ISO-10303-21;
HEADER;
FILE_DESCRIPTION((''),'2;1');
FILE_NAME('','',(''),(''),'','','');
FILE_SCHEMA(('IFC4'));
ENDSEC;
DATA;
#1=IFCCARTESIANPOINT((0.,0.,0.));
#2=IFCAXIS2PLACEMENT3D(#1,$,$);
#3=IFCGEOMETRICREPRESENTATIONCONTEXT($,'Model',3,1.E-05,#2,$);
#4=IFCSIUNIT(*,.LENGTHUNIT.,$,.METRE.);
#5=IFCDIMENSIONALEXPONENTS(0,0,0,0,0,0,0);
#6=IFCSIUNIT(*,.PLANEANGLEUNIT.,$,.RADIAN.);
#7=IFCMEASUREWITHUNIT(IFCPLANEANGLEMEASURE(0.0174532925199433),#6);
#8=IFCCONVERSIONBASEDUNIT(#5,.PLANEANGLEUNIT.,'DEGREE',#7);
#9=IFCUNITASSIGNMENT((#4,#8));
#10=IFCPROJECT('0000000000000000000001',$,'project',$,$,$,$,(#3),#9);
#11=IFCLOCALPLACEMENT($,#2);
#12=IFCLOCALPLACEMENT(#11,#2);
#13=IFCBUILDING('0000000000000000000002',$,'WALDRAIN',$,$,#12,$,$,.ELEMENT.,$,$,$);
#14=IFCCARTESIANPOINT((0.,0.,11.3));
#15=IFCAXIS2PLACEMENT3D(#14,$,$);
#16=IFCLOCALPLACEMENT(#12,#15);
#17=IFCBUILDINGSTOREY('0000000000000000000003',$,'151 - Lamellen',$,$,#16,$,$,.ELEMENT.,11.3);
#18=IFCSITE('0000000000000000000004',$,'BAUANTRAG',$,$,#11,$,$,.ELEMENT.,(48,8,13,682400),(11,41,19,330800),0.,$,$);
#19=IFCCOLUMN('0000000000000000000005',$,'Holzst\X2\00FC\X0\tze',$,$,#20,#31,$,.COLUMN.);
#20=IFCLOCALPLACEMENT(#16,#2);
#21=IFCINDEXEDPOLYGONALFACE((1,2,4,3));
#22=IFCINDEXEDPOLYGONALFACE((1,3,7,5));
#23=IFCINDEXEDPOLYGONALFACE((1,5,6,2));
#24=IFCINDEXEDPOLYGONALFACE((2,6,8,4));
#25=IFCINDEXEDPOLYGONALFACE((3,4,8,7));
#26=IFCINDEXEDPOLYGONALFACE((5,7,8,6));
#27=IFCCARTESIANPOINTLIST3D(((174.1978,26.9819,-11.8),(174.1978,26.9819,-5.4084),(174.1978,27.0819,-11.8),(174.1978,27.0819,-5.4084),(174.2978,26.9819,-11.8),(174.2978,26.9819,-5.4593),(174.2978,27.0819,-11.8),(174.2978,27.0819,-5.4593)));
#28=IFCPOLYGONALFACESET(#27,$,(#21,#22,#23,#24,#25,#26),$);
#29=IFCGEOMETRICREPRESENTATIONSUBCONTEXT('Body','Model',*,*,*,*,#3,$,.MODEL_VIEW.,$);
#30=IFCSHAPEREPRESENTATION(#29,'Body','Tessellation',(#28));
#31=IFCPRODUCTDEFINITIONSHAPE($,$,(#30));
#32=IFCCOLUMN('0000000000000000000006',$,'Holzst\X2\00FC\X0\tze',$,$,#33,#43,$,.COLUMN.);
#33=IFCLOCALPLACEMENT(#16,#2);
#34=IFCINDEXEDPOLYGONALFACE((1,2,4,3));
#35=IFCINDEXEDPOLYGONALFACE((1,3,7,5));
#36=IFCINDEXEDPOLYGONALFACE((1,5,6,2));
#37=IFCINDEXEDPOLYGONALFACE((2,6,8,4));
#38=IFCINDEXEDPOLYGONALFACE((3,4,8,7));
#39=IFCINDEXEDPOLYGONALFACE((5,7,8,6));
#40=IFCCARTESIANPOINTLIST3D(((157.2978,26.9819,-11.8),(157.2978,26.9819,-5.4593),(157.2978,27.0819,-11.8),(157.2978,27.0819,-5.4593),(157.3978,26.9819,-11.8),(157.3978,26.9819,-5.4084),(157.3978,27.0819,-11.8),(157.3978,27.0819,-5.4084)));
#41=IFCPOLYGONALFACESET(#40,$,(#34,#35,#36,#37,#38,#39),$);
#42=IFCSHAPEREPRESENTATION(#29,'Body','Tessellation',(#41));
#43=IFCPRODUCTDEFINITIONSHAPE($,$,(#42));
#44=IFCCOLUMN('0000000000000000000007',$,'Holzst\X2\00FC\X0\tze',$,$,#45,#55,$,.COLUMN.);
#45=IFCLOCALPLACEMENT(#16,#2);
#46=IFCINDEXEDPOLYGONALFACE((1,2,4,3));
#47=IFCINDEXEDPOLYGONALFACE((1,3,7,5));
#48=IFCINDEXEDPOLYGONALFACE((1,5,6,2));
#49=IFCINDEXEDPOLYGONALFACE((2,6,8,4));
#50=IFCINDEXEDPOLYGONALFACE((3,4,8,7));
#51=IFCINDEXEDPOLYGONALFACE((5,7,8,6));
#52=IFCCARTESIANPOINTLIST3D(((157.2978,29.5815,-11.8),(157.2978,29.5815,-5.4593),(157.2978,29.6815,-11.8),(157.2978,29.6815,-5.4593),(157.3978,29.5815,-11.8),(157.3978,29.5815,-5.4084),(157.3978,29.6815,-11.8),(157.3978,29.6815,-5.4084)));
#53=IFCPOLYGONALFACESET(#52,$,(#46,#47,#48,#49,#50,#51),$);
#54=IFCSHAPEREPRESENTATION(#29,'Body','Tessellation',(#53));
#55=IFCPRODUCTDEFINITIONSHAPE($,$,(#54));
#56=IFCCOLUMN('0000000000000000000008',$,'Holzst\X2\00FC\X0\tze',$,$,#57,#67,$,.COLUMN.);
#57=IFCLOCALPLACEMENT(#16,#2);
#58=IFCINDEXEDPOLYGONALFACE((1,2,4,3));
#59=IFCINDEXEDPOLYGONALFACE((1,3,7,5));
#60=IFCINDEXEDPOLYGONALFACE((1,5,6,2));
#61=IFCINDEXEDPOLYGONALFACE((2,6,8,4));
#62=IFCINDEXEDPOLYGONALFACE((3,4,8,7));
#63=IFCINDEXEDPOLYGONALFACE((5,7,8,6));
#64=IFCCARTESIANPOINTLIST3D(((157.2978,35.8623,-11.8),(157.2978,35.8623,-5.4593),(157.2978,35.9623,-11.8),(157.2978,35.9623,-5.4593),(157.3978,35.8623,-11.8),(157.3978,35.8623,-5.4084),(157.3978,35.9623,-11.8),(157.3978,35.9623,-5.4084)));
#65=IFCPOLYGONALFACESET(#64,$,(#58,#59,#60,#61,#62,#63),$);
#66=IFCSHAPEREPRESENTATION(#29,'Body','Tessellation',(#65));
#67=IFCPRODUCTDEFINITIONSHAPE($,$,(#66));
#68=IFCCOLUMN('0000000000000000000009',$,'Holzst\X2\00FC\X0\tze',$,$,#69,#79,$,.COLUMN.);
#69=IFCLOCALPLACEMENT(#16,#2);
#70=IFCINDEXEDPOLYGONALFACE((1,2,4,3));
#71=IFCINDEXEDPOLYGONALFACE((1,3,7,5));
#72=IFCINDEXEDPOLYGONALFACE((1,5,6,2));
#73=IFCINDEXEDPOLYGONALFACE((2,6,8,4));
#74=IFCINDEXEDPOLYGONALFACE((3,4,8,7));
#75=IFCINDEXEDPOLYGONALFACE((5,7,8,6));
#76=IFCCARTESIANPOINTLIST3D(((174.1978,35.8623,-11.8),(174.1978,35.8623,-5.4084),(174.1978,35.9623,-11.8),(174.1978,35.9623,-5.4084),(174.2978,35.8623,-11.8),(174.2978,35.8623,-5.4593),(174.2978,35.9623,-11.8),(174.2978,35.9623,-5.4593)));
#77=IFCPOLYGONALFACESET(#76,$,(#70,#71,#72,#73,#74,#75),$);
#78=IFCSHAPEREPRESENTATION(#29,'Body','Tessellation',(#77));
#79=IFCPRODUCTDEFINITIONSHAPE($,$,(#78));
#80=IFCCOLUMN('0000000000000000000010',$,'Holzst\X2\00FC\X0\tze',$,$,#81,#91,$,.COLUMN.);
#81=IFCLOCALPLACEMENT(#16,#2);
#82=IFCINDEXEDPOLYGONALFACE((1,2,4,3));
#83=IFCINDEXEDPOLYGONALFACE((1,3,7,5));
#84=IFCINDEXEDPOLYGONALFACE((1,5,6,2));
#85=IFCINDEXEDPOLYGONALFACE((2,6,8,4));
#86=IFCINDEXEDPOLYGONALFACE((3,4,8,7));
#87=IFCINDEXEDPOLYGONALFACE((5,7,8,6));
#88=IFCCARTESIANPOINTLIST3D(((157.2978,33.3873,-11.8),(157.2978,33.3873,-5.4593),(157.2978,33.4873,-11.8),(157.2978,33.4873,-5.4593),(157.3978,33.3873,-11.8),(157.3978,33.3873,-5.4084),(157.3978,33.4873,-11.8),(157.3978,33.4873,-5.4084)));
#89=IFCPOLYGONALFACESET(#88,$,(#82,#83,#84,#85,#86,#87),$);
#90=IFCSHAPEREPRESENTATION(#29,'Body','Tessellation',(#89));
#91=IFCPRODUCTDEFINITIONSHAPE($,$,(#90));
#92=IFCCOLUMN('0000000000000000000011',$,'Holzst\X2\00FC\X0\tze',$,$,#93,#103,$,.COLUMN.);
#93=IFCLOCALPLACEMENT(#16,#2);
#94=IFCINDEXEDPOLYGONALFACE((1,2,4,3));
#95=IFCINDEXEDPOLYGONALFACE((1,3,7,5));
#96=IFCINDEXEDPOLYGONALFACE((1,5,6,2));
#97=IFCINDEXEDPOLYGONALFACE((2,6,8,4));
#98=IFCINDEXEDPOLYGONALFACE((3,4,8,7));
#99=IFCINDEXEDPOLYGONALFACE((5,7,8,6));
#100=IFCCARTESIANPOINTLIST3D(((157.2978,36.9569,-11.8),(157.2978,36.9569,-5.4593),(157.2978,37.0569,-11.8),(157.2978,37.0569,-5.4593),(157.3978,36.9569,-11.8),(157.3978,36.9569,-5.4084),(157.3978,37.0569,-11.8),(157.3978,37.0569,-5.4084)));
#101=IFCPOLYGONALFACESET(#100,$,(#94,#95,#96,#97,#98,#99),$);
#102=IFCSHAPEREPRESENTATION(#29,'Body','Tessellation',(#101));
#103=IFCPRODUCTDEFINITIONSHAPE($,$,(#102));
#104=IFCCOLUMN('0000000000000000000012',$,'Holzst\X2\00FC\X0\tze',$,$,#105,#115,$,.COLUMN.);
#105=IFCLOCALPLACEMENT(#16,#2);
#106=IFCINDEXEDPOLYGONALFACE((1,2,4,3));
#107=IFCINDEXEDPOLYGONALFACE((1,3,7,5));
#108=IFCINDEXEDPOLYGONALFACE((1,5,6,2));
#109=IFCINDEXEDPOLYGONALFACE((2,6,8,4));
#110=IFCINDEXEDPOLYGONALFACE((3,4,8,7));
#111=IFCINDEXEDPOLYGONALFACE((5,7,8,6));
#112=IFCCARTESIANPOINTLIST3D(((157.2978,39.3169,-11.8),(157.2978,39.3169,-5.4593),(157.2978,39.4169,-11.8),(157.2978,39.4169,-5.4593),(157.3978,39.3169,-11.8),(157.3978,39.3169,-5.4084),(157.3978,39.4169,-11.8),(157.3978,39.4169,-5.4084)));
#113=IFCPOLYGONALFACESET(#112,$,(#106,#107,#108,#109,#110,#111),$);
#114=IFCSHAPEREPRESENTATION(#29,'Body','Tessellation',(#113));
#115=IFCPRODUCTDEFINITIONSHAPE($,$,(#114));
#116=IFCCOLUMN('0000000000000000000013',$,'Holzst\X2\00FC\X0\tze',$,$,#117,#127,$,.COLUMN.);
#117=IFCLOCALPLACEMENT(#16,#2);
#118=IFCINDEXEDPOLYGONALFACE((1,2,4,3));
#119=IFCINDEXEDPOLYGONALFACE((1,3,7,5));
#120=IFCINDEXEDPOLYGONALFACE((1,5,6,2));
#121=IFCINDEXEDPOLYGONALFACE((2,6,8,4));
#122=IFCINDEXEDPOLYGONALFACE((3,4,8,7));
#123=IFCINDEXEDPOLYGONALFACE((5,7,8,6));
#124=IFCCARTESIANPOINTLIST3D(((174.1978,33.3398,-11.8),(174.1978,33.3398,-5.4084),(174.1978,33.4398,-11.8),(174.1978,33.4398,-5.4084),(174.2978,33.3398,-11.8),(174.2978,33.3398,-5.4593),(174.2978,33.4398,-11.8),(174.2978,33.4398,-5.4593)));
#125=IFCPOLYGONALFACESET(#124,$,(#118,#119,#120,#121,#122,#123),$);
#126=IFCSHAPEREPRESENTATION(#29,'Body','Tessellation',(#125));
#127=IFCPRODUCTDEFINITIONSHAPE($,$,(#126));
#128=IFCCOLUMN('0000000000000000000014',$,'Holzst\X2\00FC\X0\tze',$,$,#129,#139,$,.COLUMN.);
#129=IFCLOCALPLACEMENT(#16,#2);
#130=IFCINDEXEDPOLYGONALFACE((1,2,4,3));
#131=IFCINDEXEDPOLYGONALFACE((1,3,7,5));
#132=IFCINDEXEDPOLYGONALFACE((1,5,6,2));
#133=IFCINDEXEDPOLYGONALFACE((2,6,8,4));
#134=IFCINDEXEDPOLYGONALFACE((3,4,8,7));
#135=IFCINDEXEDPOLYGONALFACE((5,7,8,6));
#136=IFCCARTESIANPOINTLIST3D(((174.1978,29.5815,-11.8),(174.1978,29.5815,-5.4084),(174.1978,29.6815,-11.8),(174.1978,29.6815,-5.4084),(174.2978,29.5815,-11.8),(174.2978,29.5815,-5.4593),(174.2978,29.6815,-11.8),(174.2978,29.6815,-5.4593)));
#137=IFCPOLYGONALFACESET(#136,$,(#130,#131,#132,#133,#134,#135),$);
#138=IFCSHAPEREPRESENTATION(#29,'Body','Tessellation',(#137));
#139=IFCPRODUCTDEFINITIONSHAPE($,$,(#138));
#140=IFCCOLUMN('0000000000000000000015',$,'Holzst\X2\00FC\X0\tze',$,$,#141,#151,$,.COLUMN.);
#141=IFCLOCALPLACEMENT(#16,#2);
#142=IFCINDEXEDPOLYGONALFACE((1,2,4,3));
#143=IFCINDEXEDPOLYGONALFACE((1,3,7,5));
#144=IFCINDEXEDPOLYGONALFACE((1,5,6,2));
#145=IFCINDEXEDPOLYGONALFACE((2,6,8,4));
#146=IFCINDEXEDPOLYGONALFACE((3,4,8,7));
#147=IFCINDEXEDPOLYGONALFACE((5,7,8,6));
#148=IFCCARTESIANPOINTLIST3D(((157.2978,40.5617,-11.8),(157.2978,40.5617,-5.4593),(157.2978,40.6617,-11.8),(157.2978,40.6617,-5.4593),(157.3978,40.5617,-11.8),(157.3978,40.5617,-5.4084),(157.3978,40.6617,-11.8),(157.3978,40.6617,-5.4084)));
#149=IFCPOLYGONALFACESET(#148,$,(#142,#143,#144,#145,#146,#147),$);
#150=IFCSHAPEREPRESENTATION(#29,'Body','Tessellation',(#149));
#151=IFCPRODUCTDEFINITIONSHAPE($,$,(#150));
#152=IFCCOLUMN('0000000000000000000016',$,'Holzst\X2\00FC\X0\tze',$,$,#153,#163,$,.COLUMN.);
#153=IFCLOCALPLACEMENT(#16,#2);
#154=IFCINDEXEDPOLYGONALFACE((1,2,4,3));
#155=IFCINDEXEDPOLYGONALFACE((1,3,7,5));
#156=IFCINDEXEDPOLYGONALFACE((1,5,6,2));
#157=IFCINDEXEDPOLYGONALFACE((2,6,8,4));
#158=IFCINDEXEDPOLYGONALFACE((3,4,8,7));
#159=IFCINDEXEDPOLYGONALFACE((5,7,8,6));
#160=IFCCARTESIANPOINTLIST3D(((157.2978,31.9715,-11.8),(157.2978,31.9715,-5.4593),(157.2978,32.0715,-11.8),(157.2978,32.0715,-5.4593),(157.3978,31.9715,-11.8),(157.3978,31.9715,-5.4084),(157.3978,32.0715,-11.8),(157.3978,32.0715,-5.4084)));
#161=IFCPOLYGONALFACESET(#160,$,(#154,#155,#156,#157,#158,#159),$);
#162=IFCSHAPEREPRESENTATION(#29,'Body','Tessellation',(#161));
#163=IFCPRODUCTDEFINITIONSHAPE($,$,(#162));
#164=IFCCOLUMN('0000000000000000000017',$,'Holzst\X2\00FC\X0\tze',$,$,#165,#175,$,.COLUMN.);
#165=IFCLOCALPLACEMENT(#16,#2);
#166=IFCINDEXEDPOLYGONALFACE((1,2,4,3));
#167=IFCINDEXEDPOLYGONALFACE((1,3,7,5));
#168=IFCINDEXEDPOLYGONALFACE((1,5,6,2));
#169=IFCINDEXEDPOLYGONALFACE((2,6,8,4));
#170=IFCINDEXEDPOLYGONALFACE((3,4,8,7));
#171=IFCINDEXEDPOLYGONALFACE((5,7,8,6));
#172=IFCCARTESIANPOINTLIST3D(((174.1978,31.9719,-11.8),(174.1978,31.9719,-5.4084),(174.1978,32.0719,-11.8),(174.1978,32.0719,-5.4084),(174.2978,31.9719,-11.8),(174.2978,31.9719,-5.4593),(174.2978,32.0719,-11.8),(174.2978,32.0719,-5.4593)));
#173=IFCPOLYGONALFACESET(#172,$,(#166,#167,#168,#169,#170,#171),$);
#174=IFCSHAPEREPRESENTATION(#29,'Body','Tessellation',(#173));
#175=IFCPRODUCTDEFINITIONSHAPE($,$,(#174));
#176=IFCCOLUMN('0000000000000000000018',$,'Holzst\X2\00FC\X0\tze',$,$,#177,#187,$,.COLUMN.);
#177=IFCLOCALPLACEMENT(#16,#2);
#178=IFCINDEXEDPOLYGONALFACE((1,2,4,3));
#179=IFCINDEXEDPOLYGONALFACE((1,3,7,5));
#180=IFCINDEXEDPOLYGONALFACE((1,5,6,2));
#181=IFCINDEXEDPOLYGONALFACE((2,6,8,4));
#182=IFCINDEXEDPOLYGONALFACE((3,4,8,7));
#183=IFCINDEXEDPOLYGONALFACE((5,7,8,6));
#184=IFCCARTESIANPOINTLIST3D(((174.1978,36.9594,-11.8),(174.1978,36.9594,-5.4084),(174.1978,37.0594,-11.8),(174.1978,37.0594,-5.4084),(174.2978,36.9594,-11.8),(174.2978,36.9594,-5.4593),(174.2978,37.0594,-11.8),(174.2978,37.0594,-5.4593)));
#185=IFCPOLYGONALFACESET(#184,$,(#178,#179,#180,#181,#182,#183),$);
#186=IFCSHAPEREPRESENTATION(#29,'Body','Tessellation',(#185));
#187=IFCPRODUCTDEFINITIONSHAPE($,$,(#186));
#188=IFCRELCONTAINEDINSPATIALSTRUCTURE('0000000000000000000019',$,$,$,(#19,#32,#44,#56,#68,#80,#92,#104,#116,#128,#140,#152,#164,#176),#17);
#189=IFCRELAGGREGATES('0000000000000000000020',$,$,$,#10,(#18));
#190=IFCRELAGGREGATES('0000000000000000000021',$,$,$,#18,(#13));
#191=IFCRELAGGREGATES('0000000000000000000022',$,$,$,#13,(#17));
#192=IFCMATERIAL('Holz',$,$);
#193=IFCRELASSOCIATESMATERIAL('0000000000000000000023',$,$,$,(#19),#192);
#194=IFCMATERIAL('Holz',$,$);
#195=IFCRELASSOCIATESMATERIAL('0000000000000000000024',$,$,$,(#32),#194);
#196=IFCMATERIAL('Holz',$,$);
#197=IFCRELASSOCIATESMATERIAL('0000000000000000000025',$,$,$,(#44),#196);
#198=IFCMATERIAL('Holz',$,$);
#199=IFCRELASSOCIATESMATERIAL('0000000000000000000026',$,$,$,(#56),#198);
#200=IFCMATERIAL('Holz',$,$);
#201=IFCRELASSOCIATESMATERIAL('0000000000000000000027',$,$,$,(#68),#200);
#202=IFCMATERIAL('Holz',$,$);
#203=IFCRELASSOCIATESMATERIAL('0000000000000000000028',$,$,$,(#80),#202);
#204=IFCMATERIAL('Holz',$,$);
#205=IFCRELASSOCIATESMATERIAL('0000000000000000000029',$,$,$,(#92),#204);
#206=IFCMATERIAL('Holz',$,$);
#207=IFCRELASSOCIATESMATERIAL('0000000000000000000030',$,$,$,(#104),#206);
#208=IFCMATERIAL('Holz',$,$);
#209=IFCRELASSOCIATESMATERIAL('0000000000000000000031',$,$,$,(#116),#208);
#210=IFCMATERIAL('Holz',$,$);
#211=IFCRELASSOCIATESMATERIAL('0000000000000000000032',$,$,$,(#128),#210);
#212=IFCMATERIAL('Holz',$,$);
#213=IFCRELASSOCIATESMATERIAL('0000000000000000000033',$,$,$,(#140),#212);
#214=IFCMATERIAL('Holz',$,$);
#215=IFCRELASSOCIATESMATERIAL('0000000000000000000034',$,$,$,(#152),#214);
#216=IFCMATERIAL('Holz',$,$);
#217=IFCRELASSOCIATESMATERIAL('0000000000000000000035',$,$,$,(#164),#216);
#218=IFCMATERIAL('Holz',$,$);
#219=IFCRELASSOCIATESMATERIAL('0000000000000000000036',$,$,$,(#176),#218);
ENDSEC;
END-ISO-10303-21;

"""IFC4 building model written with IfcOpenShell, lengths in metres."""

from ifc_helpers import new_model, entity, si_unit, converted_unit, frame, frame_2d, origin, origin_with_axes, place, context, subcontext, project, spatial, rectangle, extrude, clip, halfspace, material, element, save


model = new_model("IFC4")

# Units and contexts
model_context = context("Model", 3, precision=1e-05, world=origin())
body_context = subcontext(model_context, "Body", "Model", "MODEL_VIEW")
ifc_project = project(units=[si_unit("LENGTHUNIT", "METRE"), converted_unit("PLANEANGLEUNIT", "DEGREE", entity("IfcPlaneAngleMeasure", 0.0174532925199433), si_unit("PLANEANGLEUNIT", "RADIAN"), dimensions=[0, 0, 0, 0, 0, 0, 0])], contexts=[model_context])

# Site, building, storey
site_placement = place(None, origin())
site = spatial("IfcSite", under=ifc_project, at=site_placement, Name="BAUANTRAG", CompositionType="ELEMENT", RefLatitude=(48, 8, 13, 682400), RefLongitude=(11, 41, 19, 330800), RefElevation=0.0)
building_placement = place(site_placement, origin())
building = spatial("IfcBuilding", under=site, at=building_placement, Name="WALDRAIN", CompositionType="ELEMENT")
storey_placement = place(building_placement, frame((0.0, 0.0, 11.3)))
storey = spatial("IfcBuildingStorey", under=building, at=storey_placement, Name="151 - Lamellen", CompositionType="ELEMENT", Elevation=11.3)

# Columns
ifc_material_1 = material(Name="Holz")
column_1_placement = place(storey_placement, frame((174.2978, 26.9819, -11.8)))
element("IfcColumn", 1, at=column_1_placement, inside=storey, material=ifc_material_1, Name="Holzstütze", PredefinedType="COLUMN", context=body_context, shape_type="Clipping", body=[
    clip(extrude(rectangle(XDim=0.1, YDim=0.1, at=frame_2d((-0.05, 0.05), x_axis=(0.0, 1.0))), origin_with_axes(), (0.0, 0.0, 1.0), 6.3916), halfspace(frame((-0.05, 0.05, 6.3661), z_axis=(-0.45399, 0.0, -0.891007), x_axis=(0.0, -1.0, 0.0)), True)),
])
ifc_material_2 = material(Name="Holz")
column_2_placement = place(storey_placement, frame((157.3978, 26.9819, -11.8)))
element("IfcColumn", 2, at=column_2_placement, inside=storey, material=ifc_material_2, Name="Holzstütze", PredefinedType="COLUMN", context=body_context, shape_type="Clipping", body=[
    clip(extrude(rectangle(XDim=0.1, YDim=0.1, at=frame_2d((-0.05, 0.05), x_axis=(0.0, 1.0))), origin_with_axes(), (0.0, 0.0, 1.0), 6.3916), halfspace(frame((-0.05, 0.05, 6.3661), z_axis=(0.45399, 0.0, -0.891007), x_axis=(-0.891007, 0.0, -0.45399)), True)),
])
ifc_material_3 = material(Name="Holz")
column_3_placement = place(storey_placement, frame((157.3978, 29.5815, -11.8)))
element("IfcColumn", 3, at=column_3_placement, inside=storey, material=ifc_material_3, Name="Holzstütze", PredefinedType="COLUMN", context=body_context, shape_type="Clipping", body=[
    clip(extrude(rectangle(XDim=0.1, YDim=0.1, at=frame_2d((-0.05, 0.05), x_axis=(0.0, 1.0))), origin_with_axes(), (0.0, 0.0, 1.0), 6.3916), halfspace(frame((-0.05, 0.05, 6.3661), z_axis=(0.45399, 0.0, -0.891007), x_axis=(-0.891007, 0.0, -0.45399)), True)),
])
ifc_material_4 = material(Name="Holz")
column_4_placement = place(storey_placement, frame((157.3978, 35.8623, -11.8)))
element("IfcColumn", 4, at=column_4_placement, inside=storey, material=ifc_material_4, Name="Holzstütze", PredefinedType="COLUMN", context=body_context, shape_type="Clipping", body=[
    clip(extrude(rectangle(XDim=0.1, YDim=0.1, at=frame_2d((-0.05, 0.05), x_axis=(0.0, 1.0))), origin_with_axes(), (0.0, 0.0, 1.0), 6.3916), halfspace(frame((-0.05, 0.05, 6.3661), z_axis=(0.45399, 0.0, -0.891007), x_axis=(-0.891007, 0.0, -0.45399)), True)),
])
ifc_material_5 = material(Name="Holz")
column_5_placement = place(storey_placement, frame((174.2978, 35.8623, -11.8)))
element("IfcColumn", 5, at=column_5_placement, inside=storey, material=ifc_material_5, Name="Holzstütze", PredefinedType="COLUMN", context=body_context, shape_type="Clipping", body=[
    clip(extrude(rectangle(XDim=0.1, YDim=0.1, at=frame_2d((-0.05, 0.05), x_axis=(0.0, 1.0))), origin_with_axes(), (0.0, 0.0, 1.0), 6.3916), halfspace(frame((-0.05, 0.05, 6.3661), z_axis=(-0.45399, 0.0, -0.891007), x_axis=(0.891007, 0.0, -0.45399)), True)),
])
ifc_material_6 = material(Name="Holz")
column_6_placement = place(storey_placement, frame((157.3978, 33.3873, -11.8)))
element("IfcColumn", 6, at=column_6_placement, inside=storey, material=ifc_material_6, Name="Holzstütze", PredefinedType="COLUMN", context=body_context, shape_type="Clipping", body=[
    clip(extrude(rectangle(XDim=0.1, YDim=0.1, at=frame_2d((-0.05, 0.05), x_axis=(0.0, 1.0))), origin_with_axes(), (0.0, 0.0, 1.0), 6.3916), halfspace(frame((-0.05, 0.05, 6.3661), z_axis=(0.45399, 0.0, -0.891007), x_axis=(-0.891007, 0.0, -0.45399)), True)),
])
ifc_material_7 = material(Name="Holz")
column_7_placement = place(storey_placement, frame((157.3978, 36.9569, -11.8)))
element("IfcColumn", 7, at=column_7_placement, inside=storey, material=ifc_material_7, Name="Holzstütze", PredefinedType="COLUMN", context=body_context, shape_type="Clipping", body=[
    clip(extrude(rectangle(XDim=0.1, YDim=0.1, at=frame_2d((-0.05, 0.05), x_axis=(0.0, 1.0))), origin_with_axes(), (0.0, 0.0, 1.0), 6.3916), halfspace(frame((-0.05, 0.05, 6.3661), z_axis=(0.45399, 0.0, -0.891007), x_axis=(-0.891007, 0.0, -0.45399)), True)),
])
ifc_material_8 = material(Name="Holz")
column_8_placement = place(storey_placement, frame((157.3978, 39.3169, -11.8)))
element("IfcColumn", 8, at=column_8_placement, inside=storey, material=ifc_material_8, Name="Holzstütze", PredefinedType="COLUMN", context=body_context, shape_type="Clipping", body=[
    clip(extrude(rectangle(XDim=0.1, YDim=0.1, at=frame_2d((-0.05, 0.05), x_axis=(0.0, 1.0))), origin_with_axes(), (0.0, 0.0, 1.0), 6.3916), halfspace(frame((-0.05, 0.05, 6.3661), z_axis=(0.45399, 0.0, -0.891007), x_axis=(-0.891007, 0.0, -0.45399)), True)),
])
ifc_material_9 = material(Name="Holz")
column_9_placement = place(storey_placement, frame((174.2978, 33.3398, -11.8)))
element("IfcColumn", 9, at=column_9_placement, inside=storey, material=ifc_material_9, Name="Holzstütze", PredefinedType="COLUMN", context=body_context, shape_type="Clipping", body=[
    clip(extrude(rectangle(XDim=0.1, YDim=0.1, at=frame_2d((-0.05, 0.05), x_axis=(0.0, 1.0))), origin_with_axes(), (0.0, 0.0, 1.0), 6.3916), halfspace(frame((-0.05, 0.05, 6.3661), z_axis=(-0.45399, 0.0, -0.891007), x_axis=(0.891007, 0.0, -0.45399)), True)),
])
ifc_material_10 = material(Name="Holz")
column_10_placement = place(storey_placement, frame((174.2978, 29.5815, -11.8)))
element("IfcColumn", 10, at=column_10_placement, inside=storey, material=ifc_material_10, Name="Holzstütze", PredefinedType="COLUMN", context=body_context, shape_type="Clipping", body=[
    clip(extrude(rectangle(XDim=0.1, YDim=0.1, at=frame_2d((-0.05, 0.05), x_axis=(0.0, 1.0))), origin_with_axes(), (0.0, 0.0, 1.0), 6.3916), halfspace(frame((-0.05, 0.05, 6.3661), z_axis=(-0.45399, 0.0, -0.891007), x_axis=(0.891007, 0.0, -0.45399)), True)),
])
ifc_material_11 = material(Name="Holz")
column_11_placement = place(storey_placement, frame((157.3978, 40.5617, -11.8)))
element("IfcColumn", 11, at=column_11_placement, inside=storey, material=ifc_material_11, Name="Holzstütze", PredefinedType="COLUMN", context=body_context, shape_type="Clipping", body=[
    clip(extrude(rectangle(XDim=0.1, YDim=0.1, at=frame_2d((-0.05, 0.05), x_axis=(0.0, 1.0))), origin_with_axes(), (0.0, 0.0, 1.0), 6.3916), halfspace(frame((-0.05, 0.05, 6.3661), z_axis=(0.45399, 0.0, -0.891007), x_axis=(-0.891007, 0.0, -0.45399)), True)),
])
ifc_material_12 = material(Name="Holz")
column_12_placement = place(storey_placement, frame((157.3978, 31.9715, -11.8)))
element("IfcColumn", 12, at=column_12_placement, inside=storey, material=ifc_material_12, Name="Holzstütze", PredefinedType="COLUMN", context=body_context, shape_type="Clipping", body=[
    clip(extrude(rectangle(XDim=0.1, YDim=0.1, at=frame_2d((-0.05, 0.05), x_axis=(0.0, 1.0))), origin_with_axes(), (0.0, 0.0, 1.0), 6.3916), halfspace(frame((-0.05, 0.05, 6.3661), z_axis=(0.45399, 0.0, -0.891007), x_axis=(-0.891007, 0.0, -0.45399)), True)),
])
ifc_material_13 = material(Name="Holz")
column_13_placement = place(storey_placement, frame((174.2978, 31.9719, -11.8)))
element("IfcColumn", 13, at=column_13_placement, inside=storey, material=ifc_material_13, Name="Holzstütze", PredefinedType="COLUMN", context=body_context, shape_type="Clipping", body=[
    clip(extrude(rectangle(XDim=0.1, YDim=0.1, at=frame_2d((-0.05, 0.05), x_axis=(0.0, 1.0))), origin_with_axes(), (0.0, 0.0, 1.0), 6.3916), halfspace(frame((-0.05, 0.05, 6.3661), z_axis=(-0.45399, 0.0, -0.891007), x_axis=(0.891007, 0.0, -0.45399)), True)),
])
ifc_material_14 = material(Name="Holz")
column_14_placement = place(storey_placement, frame((174.2978, 36.9594, -11.8)))
element("IfcColumn", 14, at=column_14_placement, inside=storey, material=ifc_material_14, Name="Holzstütze", PredefinedType="COLUMN", context=body_context, shape_type="Clipping", body=[
    clip(extrude(rectangle(XDim=0.1, YDim=0.1, at=frame_2d((-0.05, 0.05), x_axis=(0.0, 1.0))), origin_with_axes(), (0.0, 0.0, 1.0), 6.3916), halfspace(frame((-0.05, 0.05, 6.3661), z_axis=(-0.45399, 0.0, -0.891007), x_axis=(0.891007, 0.0, -0.45399)), True)),
])

save(model, "model.ifc")
